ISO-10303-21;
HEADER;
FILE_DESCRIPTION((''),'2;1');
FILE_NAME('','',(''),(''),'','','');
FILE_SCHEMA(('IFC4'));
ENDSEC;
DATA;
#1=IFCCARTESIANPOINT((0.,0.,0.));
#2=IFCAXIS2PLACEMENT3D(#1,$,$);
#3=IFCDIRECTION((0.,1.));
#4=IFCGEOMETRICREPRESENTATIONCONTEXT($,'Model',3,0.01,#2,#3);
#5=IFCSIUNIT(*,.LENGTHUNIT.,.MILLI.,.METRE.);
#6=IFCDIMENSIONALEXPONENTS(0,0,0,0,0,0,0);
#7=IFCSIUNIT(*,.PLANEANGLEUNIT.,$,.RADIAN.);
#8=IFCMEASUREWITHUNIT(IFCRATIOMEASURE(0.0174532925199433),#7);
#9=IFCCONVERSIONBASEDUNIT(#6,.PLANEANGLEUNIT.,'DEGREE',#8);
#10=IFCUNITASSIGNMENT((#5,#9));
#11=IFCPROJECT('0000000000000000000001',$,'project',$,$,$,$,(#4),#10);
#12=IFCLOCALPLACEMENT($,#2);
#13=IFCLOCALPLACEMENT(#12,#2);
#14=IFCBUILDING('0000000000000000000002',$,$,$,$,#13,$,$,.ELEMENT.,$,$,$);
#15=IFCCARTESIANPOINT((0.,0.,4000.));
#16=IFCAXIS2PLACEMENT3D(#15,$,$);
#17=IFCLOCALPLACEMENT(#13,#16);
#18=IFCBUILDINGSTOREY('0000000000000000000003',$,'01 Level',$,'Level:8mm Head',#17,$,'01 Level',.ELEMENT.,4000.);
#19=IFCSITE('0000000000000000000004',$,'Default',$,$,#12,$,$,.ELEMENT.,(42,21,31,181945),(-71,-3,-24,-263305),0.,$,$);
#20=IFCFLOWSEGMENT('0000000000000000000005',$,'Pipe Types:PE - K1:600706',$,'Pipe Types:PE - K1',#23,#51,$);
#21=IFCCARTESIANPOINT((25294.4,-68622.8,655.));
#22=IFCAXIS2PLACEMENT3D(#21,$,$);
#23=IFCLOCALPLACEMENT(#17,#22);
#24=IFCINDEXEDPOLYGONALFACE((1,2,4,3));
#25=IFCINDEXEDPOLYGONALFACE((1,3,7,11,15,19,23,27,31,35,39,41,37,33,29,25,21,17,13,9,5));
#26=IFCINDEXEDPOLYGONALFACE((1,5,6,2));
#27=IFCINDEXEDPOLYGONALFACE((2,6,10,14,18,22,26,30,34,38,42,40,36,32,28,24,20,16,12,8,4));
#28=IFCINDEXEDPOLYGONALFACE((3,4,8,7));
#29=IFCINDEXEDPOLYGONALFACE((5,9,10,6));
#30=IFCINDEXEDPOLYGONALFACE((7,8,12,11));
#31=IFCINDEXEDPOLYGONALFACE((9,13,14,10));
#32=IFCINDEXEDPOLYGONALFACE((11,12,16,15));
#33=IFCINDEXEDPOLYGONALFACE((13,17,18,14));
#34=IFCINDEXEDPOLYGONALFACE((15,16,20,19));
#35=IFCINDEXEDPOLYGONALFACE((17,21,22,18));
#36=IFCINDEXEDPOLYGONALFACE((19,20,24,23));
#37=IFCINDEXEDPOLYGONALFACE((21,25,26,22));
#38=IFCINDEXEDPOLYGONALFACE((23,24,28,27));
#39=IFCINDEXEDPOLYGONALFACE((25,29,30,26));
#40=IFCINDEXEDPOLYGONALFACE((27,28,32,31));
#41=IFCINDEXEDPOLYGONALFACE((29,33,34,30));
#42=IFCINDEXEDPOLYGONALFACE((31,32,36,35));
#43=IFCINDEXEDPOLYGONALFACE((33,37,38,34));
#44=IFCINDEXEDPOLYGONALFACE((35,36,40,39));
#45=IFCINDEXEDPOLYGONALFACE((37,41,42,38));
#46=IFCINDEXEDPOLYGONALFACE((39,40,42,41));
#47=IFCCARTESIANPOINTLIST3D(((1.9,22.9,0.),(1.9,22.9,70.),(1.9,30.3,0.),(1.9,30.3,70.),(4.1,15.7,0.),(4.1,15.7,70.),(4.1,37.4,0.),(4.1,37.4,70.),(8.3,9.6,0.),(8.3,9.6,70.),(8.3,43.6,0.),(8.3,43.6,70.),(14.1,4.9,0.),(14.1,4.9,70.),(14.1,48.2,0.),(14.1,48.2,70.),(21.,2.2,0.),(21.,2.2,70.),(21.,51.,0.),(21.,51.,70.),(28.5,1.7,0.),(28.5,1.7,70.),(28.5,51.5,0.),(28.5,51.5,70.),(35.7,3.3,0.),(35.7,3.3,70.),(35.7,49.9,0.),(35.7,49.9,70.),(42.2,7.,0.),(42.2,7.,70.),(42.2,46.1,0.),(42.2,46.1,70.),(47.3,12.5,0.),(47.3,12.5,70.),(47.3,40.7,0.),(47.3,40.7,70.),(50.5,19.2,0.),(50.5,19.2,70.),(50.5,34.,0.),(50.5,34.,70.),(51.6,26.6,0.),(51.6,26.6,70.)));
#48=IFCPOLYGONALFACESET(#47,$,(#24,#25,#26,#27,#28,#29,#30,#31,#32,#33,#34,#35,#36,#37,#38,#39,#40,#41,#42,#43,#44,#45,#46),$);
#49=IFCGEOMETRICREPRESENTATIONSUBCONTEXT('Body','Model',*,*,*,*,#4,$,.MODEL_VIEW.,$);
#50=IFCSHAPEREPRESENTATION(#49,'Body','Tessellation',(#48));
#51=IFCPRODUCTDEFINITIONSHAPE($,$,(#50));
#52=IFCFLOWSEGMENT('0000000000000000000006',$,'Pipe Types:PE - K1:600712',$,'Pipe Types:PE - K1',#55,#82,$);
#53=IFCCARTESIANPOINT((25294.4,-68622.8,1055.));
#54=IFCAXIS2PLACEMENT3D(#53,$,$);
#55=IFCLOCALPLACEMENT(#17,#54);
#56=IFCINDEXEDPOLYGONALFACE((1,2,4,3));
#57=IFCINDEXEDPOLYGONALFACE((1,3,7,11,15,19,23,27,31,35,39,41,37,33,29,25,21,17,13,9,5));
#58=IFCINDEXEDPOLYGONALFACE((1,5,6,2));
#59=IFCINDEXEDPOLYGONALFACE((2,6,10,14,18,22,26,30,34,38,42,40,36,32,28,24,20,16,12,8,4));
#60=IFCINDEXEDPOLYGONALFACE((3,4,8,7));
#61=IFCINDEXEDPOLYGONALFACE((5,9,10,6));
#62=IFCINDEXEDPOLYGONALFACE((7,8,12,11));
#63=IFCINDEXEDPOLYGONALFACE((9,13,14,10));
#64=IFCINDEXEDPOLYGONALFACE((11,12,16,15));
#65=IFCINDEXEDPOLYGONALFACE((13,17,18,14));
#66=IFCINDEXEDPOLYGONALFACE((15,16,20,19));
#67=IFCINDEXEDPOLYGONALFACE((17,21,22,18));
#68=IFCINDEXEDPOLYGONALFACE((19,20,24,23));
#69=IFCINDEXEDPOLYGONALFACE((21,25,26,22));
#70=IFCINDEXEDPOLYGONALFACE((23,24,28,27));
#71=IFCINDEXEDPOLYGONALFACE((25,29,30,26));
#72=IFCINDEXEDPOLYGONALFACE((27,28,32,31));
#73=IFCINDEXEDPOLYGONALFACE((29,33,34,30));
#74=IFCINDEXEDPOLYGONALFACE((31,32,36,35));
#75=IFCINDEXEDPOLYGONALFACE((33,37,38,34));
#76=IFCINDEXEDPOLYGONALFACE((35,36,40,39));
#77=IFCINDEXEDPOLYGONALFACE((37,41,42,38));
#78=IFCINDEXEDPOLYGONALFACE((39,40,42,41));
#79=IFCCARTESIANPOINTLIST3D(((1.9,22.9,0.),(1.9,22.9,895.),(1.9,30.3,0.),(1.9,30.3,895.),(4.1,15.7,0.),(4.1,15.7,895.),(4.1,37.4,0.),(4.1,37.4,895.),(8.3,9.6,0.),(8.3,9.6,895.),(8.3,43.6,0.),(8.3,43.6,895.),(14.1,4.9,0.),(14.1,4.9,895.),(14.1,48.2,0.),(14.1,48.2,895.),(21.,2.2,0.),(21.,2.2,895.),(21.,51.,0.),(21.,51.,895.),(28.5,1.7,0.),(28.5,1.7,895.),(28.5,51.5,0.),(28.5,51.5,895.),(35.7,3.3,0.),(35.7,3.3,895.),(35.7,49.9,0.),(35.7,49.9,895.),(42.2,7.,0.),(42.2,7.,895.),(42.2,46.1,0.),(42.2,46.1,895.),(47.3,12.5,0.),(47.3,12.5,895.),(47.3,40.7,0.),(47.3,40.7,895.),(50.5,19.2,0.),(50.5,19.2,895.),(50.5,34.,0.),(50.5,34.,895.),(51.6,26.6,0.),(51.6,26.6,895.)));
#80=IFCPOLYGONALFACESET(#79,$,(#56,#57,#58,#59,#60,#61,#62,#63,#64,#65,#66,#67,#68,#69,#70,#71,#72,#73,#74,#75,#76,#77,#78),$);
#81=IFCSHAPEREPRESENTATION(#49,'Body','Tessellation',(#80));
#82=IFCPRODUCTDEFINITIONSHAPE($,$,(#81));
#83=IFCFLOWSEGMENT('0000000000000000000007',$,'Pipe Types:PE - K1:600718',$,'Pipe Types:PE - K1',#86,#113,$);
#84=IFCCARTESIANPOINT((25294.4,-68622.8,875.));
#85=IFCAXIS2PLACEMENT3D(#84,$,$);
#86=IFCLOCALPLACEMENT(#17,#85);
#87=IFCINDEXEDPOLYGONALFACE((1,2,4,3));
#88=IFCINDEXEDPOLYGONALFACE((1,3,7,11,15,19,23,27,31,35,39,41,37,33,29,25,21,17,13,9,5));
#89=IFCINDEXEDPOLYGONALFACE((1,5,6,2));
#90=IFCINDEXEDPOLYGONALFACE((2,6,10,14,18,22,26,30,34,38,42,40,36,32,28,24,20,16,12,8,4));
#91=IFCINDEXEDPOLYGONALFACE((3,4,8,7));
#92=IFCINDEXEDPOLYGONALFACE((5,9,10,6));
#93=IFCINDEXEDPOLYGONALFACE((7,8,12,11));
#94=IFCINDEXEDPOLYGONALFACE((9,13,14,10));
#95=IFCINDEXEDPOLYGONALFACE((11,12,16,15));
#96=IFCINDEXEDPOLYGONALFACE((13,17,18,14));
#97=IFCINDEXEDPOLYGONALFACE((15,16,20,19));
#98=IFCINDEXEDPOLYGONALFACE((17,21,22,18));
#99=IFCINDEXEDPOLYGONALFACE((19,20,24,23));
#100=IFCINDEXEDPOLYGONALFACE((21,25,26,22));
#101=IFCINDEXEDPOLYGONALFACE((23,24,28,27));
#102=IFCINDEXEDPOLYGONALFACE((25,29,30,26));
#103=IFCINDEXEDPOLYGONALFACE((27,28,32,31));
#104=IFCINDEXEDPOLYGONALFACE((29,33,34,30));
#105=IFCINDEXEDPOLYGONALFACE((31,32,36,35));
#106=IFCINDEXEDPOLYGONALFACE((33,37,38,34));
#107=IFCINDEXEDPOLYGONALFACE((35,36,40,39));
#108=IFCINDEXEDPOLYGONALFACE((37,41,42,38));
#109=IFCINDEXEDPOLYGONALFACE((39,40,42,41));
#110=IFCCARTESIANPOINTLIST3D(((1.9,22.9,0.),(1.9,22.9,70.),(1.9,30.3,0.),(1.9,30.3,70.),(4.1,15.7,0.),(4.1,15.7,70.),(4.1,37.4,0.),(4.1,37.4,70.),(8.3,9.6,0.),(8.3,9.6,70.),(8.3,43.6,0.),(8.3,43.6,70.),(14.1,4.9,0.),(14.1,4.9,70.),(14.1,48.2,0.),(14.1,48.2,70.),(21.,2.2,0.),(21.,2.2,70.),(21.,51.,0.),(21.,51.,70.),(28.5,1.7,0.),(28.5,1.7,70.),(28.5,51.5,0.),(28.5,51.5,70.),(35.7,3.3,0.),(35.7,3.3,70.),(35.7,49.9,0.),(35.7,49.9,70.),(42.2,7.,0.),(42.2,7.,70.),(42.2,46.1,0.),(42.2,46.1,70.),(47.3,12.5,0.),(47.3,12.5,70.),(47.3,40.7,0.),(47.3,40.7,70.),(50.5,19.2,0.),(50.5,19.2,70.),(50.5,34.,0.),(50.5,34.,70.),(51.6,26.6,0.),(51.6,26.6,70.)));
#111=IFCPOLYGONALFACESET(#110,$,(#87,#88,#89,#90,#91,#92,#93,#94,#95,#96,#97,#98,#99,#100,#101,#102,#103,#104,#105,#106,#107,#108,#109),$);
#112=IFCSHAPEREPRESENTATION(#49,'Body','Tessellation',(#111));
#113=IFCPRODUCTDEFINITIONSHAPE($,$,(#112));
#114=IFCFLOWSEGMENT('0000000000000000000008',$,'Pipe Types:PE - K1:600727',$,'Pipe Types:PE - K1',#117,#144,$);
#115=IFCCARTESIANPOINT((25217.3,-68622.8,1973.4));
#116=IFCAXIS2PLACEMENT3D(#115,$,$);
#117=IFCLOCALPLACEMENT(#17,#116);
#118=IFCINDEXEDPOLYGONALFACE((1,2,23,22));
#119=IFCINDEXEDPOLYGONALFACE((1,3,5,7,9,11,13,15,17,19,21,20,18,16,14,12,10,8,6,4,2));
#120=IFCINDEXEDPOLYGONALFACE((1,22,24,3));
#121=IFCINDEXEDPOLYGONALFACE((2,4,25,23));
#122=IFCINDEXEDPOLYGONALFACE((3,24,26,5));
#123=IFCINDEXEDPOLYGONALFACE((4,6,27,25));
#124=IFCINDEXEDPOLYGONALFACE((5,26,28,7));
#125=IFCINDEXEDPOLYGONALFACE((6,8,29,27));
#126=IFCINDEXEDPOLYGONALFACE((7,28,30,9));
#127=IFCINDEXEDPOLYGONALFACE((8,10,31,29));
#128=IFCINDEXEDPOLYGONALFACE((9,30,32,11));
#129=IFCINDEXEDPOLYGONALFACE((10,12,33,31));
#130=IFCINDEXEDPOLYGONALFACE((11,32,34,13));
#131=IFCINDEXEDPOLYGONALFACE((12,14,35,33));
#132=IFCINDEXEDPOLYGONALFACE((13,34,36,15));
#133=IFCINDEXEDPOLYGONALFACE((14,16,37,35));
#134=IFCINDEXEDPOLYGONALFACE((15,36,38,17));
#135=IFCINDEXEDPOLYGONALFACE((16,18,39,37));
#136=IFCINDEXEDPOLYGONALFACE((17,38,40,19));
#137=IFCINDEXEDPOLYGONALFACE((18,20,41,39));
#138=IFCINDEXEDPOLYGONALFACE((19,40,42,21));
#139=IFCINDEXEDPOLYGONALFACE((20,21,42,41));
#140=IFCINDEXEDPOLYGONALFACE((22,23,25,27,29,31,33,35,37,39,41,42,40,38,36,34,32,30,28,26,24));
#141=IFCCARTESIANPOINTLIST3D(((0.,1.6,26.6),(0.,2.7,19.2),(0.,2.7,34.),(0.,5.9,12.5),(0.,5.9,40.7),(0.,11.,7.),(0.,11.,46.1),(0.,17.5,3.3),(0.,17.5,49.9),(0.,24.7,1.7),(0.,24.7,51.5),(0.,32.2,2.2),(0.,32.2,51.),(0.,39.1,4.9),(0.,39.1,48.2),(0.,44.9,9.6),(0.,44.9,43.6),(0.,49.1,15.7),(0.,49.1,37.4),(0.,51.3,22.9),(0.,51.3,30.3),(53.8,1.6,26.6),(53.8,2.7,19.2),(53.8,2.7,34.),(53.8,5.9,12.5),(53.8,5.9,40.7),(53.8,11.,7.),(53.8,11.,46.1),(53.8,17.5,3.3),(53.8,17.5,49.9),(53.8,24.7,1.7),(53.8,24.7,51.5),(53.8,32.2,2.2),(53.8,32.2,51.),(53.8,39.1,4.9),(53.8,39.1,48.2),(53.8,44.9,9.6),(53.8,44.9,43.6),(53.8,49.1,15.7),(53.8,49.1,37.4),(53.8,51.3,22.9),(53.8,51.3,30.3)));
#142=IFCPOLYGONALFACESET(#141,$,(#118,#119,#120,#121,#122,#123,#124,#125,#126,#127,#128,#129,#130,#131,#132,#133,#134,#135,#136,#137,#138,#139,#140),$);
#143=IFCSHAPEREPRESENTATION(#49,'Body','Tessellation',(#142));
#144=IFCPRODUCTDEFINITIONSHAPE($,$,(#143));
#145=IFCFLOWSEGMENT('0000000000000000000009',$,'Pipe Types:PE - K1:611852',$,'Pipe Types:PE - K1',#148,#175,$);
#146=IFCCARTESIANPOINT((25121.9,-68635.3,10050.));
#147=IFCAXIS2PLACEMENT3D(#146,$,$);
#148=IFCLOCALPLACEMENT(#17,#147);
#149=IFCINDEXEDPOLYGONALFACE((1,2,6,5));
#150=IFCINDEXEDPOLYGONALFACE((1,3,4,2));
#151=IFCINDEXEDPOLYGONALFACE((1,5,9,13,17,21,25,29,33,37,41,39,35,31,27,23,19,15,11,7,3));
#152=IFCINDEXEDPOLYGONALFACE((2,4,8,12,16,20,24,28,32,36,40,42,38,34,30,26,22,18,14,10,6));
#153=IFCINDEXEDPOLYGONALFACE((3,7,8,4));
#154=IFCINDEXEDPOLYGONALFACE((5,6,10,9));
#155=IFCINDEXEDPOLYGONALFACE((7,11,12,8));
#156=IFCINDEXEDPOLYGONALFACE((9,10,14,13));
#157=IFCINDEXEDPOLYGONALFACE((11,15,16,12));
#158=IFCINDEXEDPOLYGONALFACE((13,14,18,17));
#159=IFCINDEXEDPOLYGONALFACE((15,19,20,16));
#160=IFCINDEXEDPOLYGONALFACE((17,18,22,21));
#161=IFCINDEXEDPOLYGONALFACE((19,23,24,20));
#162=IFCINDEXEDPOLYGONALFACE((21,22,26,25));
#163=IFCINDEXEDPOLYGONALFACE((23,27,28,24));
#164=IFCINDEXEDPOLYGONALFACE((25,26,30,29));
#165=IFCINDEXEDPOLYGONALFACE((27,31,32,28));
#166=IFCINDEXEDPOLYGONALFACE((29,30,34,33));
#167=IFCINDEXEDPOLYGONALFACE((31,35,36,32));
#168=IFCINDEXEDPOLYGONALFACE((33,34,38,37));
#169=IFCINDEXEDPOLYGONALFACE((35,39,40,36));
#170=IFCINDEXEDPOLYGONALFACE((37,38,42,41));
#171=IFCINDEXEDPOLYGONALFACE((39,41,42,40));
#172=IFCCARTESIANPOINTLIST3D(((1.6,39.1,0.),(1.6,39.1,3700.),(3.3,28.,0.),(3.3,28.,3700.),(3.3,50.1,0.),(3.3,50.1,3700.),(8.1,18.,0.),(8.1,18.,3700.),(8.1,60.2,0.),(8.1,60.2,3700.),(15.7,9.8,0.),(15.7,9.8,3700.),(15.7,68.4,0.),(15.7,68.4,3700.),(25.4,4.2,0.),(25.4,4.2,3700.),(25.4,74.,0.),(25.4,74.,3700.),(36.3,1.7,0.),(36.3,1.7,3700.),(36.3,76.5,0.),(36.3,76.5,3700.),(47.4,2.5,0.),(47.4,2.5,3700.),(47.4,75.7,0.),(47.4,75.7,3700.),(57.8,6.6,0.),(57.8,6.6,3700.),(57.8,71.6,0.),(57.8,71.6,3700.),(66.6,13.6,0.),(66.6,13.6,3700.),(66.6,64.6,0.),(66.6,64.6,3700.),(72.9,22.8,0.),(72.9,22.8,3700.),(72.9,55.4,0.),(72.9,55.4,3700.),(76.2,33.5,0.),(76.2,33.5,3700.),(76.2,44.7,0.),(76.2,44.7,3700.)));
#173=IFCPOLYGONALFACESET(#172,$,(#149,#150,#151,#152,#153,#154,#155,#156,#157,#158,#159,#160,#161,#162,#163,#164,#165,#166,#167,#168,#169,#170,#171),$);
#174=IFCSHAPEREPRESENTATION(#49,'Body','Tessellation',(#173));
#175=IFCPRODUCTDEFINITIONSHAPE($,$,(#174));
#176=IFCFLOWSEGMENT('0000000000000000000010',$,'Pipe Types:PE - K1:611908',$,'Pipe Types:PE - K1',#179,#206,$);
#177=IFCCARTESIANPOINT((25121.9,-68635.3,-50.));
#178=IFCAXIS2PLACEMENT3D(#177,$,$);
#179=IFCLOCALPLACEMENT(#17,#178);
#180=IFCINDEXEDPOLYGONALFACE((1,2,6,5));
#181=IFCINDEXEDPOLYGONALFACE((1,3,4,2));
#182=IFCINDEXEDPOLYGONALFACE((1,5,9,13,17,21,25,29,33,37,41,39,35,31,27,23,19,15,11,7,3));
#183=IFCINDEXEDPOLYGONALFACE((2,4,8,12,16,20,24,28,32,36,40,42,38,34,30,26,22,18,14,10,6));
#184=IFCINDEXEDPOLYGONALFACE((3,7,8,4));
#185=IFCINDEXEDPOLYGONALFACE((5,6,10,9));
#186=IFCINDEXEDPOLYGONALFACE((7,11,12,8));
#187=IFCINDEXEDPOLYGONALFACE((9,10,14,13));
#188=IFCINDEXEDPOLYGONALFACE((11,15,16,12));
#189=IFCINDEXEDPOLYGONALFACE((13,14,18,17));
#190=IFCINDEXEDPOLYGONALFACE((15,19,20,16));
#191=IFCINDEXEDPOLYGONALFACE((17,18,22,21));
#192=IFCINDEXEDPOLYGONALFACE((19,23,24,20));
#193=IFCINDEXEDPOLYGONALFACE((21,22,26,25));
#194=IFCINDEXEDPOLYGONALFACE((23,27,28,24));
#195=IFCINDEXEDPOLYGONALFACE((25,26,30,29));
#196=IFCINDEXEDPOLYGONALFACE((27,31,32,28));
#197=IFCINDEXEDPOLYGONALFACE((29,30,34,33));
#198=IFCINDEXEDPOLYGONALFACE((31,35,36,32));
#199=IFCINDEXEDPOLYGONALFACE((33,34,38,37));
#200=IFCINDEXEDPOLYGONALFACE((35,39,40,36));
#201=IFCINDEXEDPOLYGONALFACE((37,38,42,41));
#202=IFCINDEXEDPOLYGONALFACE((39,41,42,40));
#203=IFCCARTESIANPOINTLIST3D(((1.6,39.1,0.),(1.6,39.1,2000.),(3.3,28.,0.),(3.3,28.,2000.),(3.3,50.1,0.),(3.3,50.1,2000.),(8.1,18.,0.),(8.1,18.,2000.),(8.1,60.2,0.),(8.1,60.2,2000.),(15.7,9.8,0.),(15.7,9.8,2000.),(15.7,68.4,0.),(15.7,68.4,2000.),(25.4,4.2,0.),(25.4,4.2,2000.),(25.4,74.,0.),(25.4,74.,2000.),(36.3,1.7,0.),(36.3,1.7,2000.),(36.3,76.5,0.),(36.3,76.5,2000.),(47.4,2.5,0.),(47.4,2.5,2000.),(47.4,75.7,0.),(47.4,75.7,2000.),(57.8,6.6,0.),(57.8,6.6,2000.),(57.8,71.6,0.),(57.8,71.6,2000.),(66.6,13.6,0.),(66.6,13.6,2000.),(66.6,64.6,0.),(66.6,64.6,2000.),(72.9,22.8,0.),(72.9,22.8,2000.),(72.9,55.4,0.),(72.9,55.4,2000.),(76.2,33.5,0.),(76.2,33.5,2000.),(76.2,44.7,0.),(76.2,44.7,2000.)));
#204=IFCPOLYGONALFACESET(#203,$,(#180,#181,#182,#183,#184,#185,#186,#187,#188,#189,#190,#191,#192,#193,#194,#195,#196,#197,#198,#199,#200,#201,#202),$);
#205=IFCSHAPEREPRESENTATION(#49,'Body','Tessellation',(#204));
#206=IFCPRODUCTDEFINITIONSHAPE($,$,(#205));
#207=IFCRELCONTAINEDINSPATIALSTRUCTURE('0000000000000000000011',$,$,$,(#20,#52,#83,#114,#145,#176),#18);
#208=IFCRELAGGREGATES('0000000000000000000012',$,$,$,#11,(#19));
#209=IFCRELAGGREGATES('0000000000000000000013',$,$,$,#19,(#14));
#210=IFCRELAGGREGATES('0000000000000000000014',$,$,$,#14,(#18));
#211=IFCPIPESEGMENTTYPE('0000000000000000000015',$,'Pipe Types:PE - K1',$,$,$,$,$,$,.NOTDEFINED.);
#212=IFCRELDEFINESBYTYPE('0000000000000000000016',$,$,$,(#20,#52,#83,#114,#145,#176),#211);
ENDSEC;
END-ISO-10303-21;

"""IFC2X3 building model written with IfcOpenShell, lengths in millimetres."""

from ifc_helpers import new_model, entity, si_unit, converted_unit, direction, frame, frame_2d, origin, origin_2d_with_axis, place, context, subcontext, project, spatial, circle, extrude, type_object, element, save


model = new_model("IFC2X3")

# Units and contexts
model_context = context("Model", 3, precision=0.01, world=origin(), true_north=direction((0.0, 1.0)))
body_context = subcontext(model_context, "Body", "Model", "MODEL_VIEW")
ifc_project = project(units=[si_unit("LENGTHUNIT", "METRE", prefix="MILLI"), converted_unit("PLANEANGLEUNIT", "DEGREE", entity("IfcRatioMeasure", 0.0174532925199433), si_unit("PLANEANGLEUNIT", "RADIAN"), dimensions=[0, 0, 0, 0, 0, 0, 0])], contexts=[model_context])

# Site, building, storey
site_placement = place(None, origin())
site = spatial("IfcSite", under=ifc_project, at=site_placement, Name="Default", CompositionType="ELEMENT", RefLatitude=(42, 21, 31, 181945), RefLongitude=(-71, -3, -24, -263305), RefElevation=0.0)
building_placement = place(site_placement, origin())
building = spatial("IfcBuilding", under=site, at=building_placement, CompositionType="ELEMENT")
storey_placement = place(building_placement, frame((0.0, 0.0, 4000.0)))
storey = spatial("IfcBuildingStorey", under=building, at=storey_placement, Name="01 Level", ObjectType="Level:8mm Head", LongName="01 Level", CompositionType="ELEMENT", Elevation=4000.0)

# Flow segments
pipe_segment_type_1 = type_object("IfcPipeSegmentType", Name="Pipe Types:PE - K1", PredefinedType="NOTDEFINED")
flow_segment_1_placement = place(storey_placement, frame((25294.4, -68622.8, 655.0)))
element("IfcFlowSegment", 1, at=flow_segment_1_placement, inside=storey, type_object=pipe_segment_type_1, Name="Pipe Types:PE - K1:600706", ObjectType="Pipe Types:PE - K1", context=body_context, shape_type="SweptSolid", body=[
    extrude(circle(Radius=25.0, at=frame_2d((0.0, 0.0), x_axis=(1.0, 0.0))), frame((26.6, 26.6, 0.0)), (0.0, 0.0, 1.0), 70.0),
])
flow_segment_2_placement = place(storey_placement, frame((25294.4, -68622.8, 1055.0)))
element("IfcFlowSegment", 2, at=flow_segment_2_placement, inside=storey, type_object=pipe_segment_type_1, Name="Pipe Types:PE - K1:600712", ObjectType="Pipe Types:PE - K1", context=body_context, shape_type="SweptSolid", body=[
    extrude(circle(Radius=25.0, at=origin_2d_with_axis()), frame((26.6, 26.6, 0.0)), (0.0, 0.0, 1.0), 895.0),
])
flow_segment_3_placement = place(storey_placement, frame((25294.4, -68622.8, 875.0)))
element("IfcFlowSegment", 3, at=flow_segment_3_placement, inside=storey, type_object=pipe_segment_type_1, Name="Pipe Types:PE - K1:600718", ObjectType="Pipe Types:PE - K1", context=body_context, shape_type="SweptSolid", body=[
    extrude(circle(Radius=25.0, at=origin_2d_with_axis()), frame((26.6, 26.6, 0.0)), (0.0, 0.0, 1.0), 70.0),
])
flow_segment_4_placement = place(storey_placement, frame((25217.3, -68622.8, 1973.4)))
element("IfcFlowSegment", 4, at=flow_segment_4_placement, inside=storey, type_object=pipe_segment_type_1, Name="Pipe Types:PE - K1:600727", ObjectType="Pipe Types:PE - K1", context=body_context, shape_type="SweptSolid", body=[
    extrude(circle(Radius=25.0, at=frame_2d((0.0, 0.0), x_axis=(1.0, 0.0))), frame((0.0, 26.6, 26.6), z_axis=(1.0, 0.0, 0.0), x_axis=(0.0, -1.0, 0.0)), (0.0, 0.0, 1.0), 53.8),
])
flow_segment_5_placement = place(storey_placement, frame((25121.9, -68635.3, 10050.0)))
element("IfcFlowSegment", 5, at=flow_segment_5_placement, inside=storey, type_object=pipe_segment_type_1, Name="Pipe Types:PE - K1:611852", ObjectType="Pipe Types:PE - K1", context=body_context, shape_type="SweptSolid", body=[
    extrude(circle(Radius=37.5, at=origin_2d_with_axis()), frame((39.1, 39.1, 0.0), z_axis=(0.0, 0.0, 1.0), x_axis=(-1.0, 0.0, 0.0)), (0.0, 0.0, 1.0), 3700.0),
])
flow_segment_6_placement = place(storey_placement, frame((25121.9, -68635.3, -50.0)))
element("IfcFlowSegment", 6, at=flow_segment_6_placement, inside=storey, type_object=pipe_segment_type_1, Name="Pipe Types:PE - K1:611908", ObjectType="Pipe Types:PE - K1", context=body_context, shape_type="SweptSolid", body=[
    extrude(circle(Radius=37.5, at=origin_2d_with_axis()), frame((39.1, 39.1, 0.0), z_axis=(0.0, 0.0, 1.0), x_axis=(-1.0, 0.0, 0.0)), (0.0, 0.0, 1.0), 2000.0),
])

save(model, "model.ifc")
